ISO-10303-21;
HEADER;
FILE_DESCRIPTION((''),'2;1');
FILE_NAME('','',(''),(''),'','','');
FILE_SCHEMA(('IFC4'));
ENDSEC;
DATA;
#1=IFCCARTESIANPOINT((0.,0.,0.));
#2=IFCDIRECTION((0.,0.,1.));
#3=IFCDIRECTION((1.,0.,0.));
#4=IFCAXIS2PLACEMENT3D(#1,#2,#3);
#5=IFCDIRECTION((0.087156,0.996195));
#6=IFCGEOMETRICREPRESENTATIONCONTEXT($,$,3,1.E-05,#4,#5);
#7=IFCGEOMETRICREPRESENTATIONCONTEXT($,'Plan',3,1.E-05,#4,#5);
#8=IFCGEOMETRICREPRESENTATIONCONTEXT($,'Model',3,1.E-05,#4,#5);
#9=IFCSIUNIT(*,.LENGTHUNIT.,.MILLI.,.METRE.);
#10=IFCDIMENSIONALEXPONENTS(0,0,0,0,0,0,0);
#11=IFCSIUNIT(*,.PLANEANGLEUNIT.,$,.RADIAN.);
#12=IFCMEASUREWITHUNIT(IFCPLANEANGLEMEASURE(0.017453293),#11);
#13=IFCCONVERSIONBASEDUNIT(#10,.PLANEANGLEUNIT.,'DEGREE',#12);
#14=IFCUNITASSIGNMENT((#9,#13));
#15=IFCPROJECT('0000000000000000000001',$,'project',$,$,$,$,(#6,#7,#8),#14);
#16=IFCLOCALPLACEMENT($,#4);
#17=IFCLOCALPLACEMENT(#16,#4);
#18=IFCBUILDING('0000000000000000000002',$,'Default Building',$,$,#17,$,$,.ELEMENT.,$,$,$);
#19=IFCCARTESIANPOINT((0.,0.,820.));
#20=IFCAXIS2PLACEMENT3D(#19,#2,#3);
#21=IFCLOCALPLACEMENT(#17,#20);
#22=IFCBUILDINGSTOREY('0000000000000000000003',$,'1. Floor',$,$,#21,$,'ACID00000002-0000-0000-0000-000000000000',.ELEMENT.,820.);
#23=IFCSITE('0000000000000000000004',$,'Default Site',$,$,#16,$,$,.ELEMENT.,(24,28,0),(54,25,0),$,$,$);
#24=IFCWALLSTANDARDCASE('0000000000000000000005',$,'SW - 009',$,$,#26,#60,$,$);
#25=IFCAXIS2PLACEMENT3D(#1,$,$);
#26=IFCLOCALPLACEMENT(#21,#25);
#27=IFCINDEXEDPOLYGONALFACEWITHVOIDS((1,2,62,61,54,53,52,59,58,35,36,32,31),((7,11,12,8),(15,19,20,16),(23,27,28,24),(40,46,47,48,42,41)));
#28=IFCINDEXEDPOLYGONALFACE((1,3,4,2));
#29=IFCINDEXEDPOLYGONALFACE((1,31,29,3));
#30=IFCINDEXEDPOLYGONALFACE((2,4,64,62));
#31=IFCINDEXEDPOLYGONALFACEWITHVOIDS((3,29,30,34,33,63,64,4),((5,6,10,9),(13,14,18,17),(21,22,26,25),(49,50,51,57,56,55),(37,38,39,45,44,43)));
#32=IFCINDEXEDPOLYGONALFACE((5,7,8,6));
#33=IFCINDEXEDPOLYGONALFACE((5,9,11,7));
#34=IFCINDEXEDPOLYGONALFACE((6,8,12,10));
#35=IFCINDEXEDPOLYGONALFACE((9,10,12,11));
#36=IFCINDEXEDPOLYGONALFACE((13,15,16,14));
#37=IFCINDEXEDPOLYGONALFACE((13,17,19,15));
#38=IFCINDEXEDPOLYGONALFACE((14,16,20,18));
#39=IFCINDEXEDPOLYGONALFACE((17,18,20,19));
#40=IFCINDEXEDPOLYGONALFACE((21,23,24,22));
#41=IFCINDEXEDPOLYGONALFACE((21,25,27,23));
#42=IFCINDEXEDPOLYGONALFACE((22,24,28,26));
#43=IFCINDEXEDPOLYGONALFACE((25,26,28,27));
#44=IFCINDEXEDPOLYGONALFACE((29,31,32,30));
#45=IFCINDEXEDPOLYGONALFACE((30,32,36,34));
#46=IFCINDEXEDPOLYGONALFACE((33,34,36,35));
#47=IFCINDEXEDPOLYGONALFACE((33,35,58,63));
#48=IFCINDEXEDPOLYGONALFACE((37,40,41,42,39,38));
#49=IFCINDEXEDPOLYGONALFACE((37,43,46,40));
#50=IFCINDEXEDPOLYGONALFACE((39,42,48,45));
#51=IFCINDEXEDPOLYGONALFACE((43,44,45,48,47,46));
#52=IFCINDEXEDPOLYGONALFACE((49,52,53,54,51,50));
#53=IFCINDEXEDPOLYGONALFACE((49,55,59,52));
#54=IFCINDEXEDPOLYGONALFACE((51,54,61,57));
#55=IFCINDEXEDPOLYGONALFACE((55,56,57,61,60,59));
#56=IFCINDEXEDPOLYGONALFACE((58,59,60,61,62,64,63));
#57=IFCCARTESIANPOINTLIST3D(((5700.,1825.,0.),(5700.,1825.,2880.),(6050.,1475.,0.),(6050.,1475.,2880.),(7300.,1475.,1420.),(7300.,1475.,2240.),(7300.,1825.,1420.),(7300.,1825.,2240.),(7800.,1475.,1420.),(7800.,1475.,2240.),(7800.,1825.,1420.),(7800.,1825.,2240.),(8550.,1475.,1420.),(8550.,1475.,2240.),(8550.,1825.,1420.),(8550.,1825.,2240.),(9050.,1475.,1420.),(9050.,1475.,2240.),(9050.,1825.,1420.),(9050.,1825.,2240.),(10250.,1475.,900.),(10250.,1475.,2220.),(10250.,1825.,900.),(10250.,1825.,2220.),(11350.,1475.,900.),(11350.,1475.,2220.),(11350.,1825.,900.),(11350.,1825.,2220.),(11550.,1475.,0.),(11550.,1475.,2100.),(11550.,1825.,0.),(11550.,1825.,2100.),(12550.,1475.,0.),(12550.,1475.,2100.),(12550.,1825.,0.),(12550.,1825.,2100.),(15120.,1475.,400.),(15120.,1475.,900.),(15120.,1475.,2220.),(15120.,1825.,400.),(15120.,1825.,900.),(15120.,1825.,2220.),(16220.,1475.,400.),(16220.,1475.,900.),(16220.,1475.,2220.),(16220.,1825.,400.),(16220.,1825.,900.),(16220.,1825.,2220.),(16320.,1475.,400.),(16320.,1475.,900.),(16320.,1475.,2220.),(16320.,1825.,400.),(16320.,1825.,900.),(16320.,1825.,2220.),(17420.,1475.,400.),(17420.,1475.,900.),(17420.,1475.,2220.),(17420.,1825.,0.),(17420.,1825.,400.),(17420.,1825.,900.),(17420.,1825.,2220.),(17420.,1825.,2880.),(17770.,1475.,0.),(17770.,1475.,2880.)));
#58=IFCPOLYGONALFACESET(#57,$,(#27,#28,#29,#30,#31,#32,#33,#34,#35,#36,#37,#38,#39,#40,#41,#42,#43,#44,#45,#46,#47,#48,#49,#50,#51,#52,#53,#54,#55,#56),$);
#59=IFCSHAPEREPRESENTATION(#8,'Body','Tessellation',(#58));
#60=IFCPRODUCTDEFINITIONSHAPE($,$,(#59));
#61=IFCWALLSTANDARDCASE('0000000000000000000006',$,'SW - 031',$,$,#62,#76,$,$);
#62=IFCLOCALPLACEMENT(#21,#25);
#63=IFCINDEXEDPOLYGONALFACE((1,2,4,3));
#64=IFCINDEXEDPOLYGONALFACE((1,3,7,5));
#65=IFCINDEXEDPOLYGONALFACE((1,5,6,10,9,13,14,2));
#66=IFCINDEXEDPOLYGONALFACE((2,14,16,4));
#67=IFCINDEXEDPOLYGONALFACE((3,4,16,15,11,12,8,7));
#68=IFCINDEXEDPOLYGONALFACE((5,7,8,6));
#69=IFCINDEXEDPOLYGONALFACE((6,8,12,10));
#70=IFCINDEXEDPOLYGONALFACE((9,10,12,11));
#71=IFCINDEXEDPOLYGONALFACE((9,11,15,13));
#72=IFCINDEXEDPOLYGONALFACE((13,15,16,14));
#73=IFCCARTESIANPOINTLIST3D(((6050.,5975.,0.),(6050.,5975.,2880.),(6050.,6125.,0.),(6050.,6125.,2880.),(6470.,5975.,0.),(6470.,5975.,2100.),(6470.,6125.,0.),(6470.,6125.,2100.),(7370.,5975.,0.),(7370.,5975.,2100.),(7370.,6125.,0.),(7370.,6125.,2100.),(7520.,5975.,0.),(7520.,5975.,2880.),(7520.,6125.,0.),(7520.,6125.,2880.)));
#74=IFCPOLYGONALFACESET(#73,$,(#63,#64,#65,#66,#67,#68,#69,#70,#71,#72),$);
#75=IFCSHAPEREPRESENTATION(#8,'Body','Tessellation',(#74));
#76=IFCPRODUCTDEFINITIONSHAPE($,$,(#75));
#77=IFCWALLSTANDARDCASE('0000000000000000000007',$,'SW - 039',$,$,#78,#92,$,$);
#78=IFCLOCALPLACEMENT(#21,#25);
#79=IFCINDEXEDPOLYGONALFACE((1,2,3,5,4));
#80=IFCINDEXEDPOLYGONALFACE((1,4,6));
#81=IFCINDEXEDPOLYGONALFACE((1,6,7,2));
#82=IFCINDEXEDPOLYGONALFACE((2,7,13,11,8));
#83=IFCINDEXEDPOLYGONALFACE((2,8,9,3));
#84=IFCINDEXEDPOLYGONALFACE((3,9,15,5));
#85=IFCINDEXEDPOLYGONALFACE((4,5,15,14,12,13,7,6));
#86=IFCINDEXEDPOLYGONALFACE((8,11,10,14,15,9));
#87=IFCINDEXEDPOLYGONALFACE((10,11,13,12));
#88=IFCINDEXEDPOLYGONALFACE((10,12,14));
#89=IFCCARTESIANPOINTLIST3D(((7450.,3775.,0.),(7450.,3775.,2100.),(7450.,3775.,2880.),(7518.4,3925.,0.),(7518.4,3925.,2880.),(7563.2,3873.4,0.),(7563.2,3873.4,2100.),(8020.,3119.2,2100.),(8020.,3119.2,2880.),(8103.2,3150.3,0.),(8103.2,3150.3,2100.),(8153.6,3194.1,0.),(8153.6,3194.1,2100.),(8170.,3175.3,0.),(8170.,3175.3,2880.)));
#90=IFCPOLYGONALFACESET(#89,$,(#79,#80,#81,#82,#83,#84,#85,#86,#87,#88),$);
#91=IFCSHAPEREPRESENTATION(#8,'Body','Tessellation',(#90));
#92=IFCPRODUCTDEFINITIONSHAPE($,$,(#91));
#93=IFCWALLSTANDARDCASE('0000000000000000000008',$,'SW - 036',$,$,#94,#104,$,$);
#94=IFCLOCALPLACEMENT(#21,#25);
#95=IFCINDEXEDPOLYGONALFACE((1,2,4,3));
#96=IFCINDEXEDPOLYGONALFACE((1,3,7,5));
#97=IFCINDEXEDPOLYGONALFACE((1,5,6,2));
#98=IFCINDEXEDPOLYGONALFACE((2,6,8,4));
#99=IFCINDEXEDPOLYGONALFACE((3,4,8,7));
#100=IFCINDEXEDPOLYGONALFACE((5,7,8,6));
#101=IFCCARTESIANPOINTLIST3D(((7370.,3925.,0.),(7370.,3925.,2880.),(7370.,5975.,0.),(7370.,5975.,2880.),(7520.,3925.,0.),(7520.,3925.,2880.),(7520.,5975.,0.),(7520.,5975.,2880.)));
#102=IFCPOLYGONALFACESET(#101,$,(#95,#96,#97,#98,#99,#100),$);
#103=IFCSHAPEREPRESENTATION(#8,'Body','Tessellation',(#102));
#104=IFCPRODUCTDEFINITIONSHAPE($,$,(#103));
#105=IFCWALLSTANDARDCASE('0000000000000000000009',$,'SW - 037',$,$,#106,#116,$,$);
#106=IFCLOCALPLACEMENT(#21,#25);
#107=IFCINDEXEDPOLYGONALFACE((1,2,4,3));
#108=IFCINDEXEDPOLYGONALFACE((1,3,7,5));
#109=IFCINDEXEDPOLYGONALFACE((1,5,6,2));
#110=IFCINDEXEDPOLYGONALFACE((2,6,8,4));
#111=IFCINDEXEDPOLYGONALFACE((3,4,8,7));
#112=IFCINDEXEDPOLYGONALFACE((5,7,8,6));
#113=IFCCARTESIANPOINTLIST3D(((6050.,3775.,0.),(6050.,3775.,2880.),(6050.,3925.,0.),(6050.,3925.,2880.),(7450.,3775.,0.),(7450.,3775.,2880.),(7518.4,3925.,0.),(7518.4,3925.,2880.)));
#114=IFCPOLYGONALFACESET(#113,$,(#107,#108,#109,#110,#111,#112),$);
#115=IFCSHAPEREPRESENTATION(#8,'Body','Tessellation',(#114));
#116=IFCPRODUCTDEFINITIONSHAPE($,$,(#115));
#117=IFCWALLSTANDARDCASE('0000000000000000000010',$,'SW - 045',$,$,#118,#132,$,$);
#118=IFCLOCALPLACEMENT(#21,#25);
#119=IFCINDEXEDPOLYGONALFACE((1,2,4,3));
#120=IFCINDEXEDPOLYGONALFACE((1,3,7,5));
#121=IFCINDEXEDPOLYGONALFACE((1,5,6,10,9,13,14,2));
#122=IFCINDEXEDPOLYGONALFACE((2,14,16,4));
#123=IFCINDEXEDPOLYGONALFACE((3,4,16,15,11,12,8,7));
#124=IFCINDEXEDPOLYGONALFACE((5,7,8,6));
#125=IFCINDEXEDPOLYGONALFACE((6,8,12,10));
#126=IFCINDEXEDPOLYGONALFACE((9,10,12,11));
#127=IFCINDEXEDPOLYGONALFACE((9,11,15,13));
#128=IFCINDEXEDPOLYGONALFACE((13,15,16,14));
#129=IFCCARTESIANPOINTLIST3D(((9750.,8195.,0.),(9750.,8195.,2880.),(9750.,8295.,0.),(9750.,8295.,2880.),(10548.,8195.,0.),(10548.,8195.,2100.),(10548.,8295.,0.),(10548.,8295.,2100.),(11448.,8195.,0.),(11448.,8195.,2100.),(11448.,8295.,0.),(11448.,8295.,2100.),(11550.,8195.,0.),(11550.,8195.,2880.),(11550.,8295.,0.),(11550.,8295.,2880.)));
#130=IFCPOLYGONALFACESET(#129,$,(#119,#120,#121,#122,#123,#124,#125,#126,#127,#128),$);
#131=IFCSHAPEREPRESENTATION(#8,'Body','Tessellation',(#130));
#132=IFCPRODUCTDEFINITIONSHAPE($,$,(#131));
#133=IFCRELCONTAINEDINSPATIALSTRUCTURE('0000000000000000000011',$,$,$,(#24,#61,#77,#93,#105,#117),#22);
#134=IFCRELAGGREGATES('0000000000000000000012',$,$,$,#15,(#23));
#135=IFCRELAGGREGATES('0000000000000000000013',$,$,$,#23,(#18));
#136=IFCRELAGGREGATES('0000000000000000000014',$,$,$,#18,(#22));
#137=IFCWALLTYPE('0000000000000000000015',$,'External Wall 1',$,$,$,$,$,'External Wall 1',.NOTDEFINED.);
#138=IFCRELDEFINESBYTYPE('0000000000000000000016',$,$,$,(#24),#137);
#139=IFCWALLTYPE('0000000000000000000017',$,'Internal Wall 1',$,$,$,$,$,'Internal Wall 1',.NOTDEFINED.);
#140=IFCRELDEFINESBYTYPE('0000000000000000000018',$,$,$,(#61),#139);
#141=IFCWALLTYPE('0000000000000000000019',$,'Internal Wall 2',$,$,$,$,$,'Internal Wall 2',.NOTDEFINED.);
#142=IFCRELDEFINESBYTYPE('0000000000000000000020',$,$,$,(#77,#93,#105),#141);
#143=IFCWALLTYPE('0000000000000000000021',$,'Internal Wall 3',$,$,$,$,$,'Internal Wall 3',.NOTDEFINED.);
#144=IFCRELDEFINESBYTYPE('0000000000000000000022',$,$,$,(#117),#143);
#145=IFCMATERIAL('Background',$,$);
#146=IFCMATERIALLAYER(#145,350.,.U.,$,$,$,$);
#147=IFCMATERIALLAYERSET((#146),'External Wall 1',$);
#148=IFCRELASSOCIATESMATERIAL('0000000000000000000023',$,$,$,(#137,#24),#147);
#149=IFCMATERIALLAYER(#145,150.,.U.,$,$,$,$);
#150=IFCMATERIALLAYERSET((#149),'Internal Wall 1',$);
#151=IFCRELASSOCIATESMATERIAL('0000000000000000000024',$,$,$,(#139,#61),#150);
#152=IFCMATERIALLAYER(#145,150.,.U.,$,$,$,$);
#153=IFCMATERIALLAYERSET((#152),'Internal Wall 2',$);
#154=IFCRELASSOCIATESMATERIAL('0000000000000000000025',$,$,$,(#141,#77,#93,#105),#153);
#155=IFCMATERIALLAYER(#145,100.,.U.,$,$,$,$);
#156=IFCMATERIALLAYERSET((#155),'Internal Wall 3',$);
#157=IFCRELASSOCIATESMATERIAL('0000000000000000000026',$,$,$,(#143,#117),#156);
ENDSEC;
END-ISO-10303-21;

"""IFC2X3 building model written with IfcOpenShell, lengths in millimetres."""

from ifc_helpers import new_model, entity, si_unit, converted_unit, direction, frame, frame_2d, origin_with_axes, place, context, project, spatial, polyline, rectangle, outline, extrude, material, layer, layer_set, layer_usage, type_object, element, save


model = new_model("IFC2X3")

# Units and contexts
context_of_model = context(None, 3, precision=1e-05, world=origin_with_axes(), true_north=direction((0.087156, 0.996195)))
plan_context = context("Plan", 3, precision=1e-05, world=origin_with_axes(), true_north=direction((0.087156, 0.996195)))
model_context = context("Model", 3, precision=1e-05, world=origin_with_axes(), true_north=direction((0.087156, 0.996195)))
ifc_project = project(units=[si_unit("LENGTHUNIT", "METRE", prefix="MILLI"), converted_unit("PLANEANGLEUNIT", "DEGREE", entity("IfcPlaneAngleMeasure", 0.017453293), si_unit("PLANEANGLEUNIT", "RADIAN"), dimensions=[0, 0, 0, 0, 0, 0, 0])], contexts=[context_of_model, plan_context, model_context])

# Site, building, storey
site_placement = place(None, origin_with_axes())
site = spatial("IfcSite", under=ifc_project, at=site_placement, Name="Default Site", CompositionType="ELEMENT", RefLatitude=(24, 28, 0), RefLongitude=(54, 25, 0))
building_placement = place(site_placement, origin_with_axes())
building = spatial("IfcBuilding", under=site, at=building_placement, Name="Default Building", CompositionType="ELEMENT")
storey_placement = place(building_placement, frame((0.0, 0.0, 820.0), z_axis=(0.0, 0.0, 1.0), x_axis=(1.0, 0.0, 0.0)))
storey = spatial("IfcBuildingStorey", under=building, at=storey_placement, Name="1. Floor", LongName="ACID00000002-0000-0000-0000-000000000000", CompositionType="ELEMENT", Elevation=820.0)

# Shared definitions
ifc_material_1 = material(Name="Background")

# Shared definitions
ifc_layer_1 = layer(ifc_material_1, 350.0, ventilated="UNKNOWN")
ifc_layer_set_1 = layer_set([ifc_layer_1], Name="External Wall 1")
wall_type_1 = type_object("IfcWallType", Name="External Wall 1", ElementType="External Wall 1", PredefinedType="NOTDEFINED", material=ifc_layer_set_1)

# Wall, openings
ifc_layer_usage_1 = layer_usage(ifc_layer_set_1, "AXIS2", "POSITIVE", 0.0)
wall_1_placement = place(storey_placement, frame((6050.0, 1475.0, 0.0), z_axis=(0.0, 0.0, 1.0), x_axis=(1.0, 0.0, 0.0)))
wall_1 = element("IfcWallStandardCase", 1, at=wall_1_placement, inside=storey, type_object=wall_type_1, material=ifc_layer_usage_1, Name="SW - 009", context=model_context, shape_type="SweptSolid", body=[
    extrude(outline(polyline([(0.0, 0.0), (11720.0, 0.0), (11370.0, 350.0), (-350.0, 350.0), (0.0, 0.0)])), origin_with_axes(), (0.0, 0.0, 1.0), 2880.0),
])
opening_1_placement = place(wall_1_placement, frame((6000.0, 0.0, 0.0), z_axis=(0.0, 0.0, 1.0), x_axis=(1.0, 0.0, 0.0)))
element("IfcOpeningElement", 2, at=opening_1_placement, cuts=wall_1, ObjectType="Opening", context=model_context, shape_type="SweptSolid", body=[
    extrude(rectangle(XDim=1000.0, YDim=2100.0, at=frame_2d((0.0, 1050.0), x_axis=(-1.0, 0.0))), frame((0.0, 0.0, 0.0), z_axis=(0.0, 1.0, 0.0), x_axis=(-1.0, 0.0, 0.0)), (0.0, 0.0, 1.0), 350.0),
])
opening_2_placement = place(wall_1_placement, frame((10820.0, 0.0, 900.0), z_axis=(0.0, 0.0, 1.0), x_axis=(1.0, 0.0, 0.0)))
element("IfcOpeningElement", 3, at=opening_2_placement, cuts=wall_1, ObjectType="Opening", context=model_context, shape_type="SweptSolid", body=[
    extrude(outline(polyline([(-550.0, 0.0), (550.0, 0.0), (550.0, 1320.0), (-550.0, 1320.0), (-550.0, 0.0)])), frame((0.0, 0.0, 0.0), z_axis=(0.0, 1.0, 0.0), x_axis=(-1.0, 0.0, 0.0)), (0.0, 0.0, 1.0), 350.0),
])
opening_3_placement = place(wall_1_placement, frame((9620.0, 0.0, 900.0), z_axis=(0.0, 0.0, 1.0), x_axis=(1.0, 0.0, 0.0)))
element("IfcOpeningElement", 4, at=opening_3_placement, cuts=wall_1, ObjectType="Opening", context=model_context, shape_type="SweptSolid", body=[
    extrude(outline(polyline([(-550.0, 0.0), (550.0, 0.0), (550.0, 1320.0), (-550.0, 1320.0), (-550.0, 0.0)])), frame((0.0, 0.0, 0.0), z_axis=(0.0, 1.0, 0.0), x_axis=(-1.0, 0.0, 0.0)), (0.0, 0.0, 1.0), 350.0),
])
opening_4_placement = place(wall_1_placement, frame((10820.0, 0.0, 400.0), z_axis=(0.0, 0.0, 1.0), x_axis=(1.0, 0.0, 0.0)))
element("IfcOpeningElement", 5, at=opening_4_placement, cuts=wall_1, ObjectType="Opening", context=model_context, shape_type="SweptSolid", body=[
    extrude(outline(polyline([(-550.0, 0.0), (550.0, 0.0), (550.0, 500.0), (-550.0, 500.0), (-550.0, 0.0)])), frame((0.0, 0.0, 0.0), z_axis=(0.0, 1.0, 0.0), x_axis=(-1.0, 0.0, 0.0)), (0.0, 0.0, 1.0), 350.0),
])
opening_5_placement = place(wall_1_placement, frame((9620.0, 0.0, 400.0), z_axis=(0.0, 0.0, 1.0), x_axis=(1.0, 0.0, 0.0)))
element("IfcOpeningElement", 6, at=opening_5_placement, cuts=wall_1, ObjectType="Opening", context=model_context, shape_type="SweptSolid", body=[
    extrude(outline(polyline([(-550.0, 0.0), (550.0, 0.0), (550.0, 500.0), (-550.0, 500.0), (-550.0, 0.0)])), frame((0.0, 0.0, 0.0), z_axis=(0.0, 1.0, 0.0), x_axis=(-1.0, 0.0, 0.0)), (0.0, 0.0, 1.0), 350.0),
])
opening_6_placement = place(wall_1_placement, frame((4750.0, 0.0, 900.0), z_axis=(0.0, 0.0, 1.0), x_axis=(1.0, 0.0, 0.0)))
element("IfcOpeningElement", 7, at=opening_6_placement, cuts=wall_1, ObjectType="Opening", context=model_context, shape_type="SweptSolid", body=[
    extrude(rectangle(XDim=1100.0, YDim=1320.0, at=frame_2d((0.0, 660.0), x_axis=(1.0, 0.0))), frame((0.0, 0.0, 0.0), z_axis=(0.0, 1.0, 0.0), x_axis=(-1.0, 0.0, 0.0)), (0.0, 0.0, 1.0), 350.0),
])
opening_7_placement = place(wall_1_placement, frame((1500.0, 0.0, 1420.0), z_axis=(0.0, 0.0, 1.0), x_axis=(1.0, 0.0, 0.0)))
element("IfcOpeningElement", 8, at=opening_7_placement, cuts=wall_1, ObjectType="Opening", context=model_context, shape_type="SweptSolid", body=[
    extrude(rectangle(XDim=500.0, YDim=820.0, at=frame_2d((0.0, 410.0), x_axis=(1.0, 0.0))), frame((0.0, 0.0, 0.0), z_axis=(0.0, 1.0, 0.0), x_axis=(-1.0, 0.0, 0.0)), (0.0, 0.0, 1.0), 350.0),
])
opening_8_placement = place(wall_1_placement, frame((2750.0, 0.0, 1420.0), z_axis=(0.0, 0.0, 1.0), x_axis=(1.0, 0.0, 0.0)))
element("IfcOpeningElement", 9, at=opening_8_placement, cuts=wall_1, ObjectType="Opening", context=model_context, shape_type="SweptSolid", body=[
    extrude(rectangle(XDim=500.0, YDim=820.0, at=frame_2d((0.0, 410.0), x_axis=(1.0, 0.0))), frame((0.0, 0.0, 0.0), z_axis=(0.0, 1.0, 0.0), x_axis=(-1.0, 0.0, 0.0)), (0.0, 0.0, 1.0), 350.0),
])

# Walls, openings
ifc_layer_2 = layer(ifc_material_1, 150.0, ventilated="UNKNOWN")
ifc_layer_set_2 = layer_set([ifc_layer_2], Name="Internal Wall 1")
ifc_layer_usage_2 = layer_usage(ifc_layer_set_2, "AXIS2", "NEGATIVE", 0.0)
wall_type_2 = type_object("IfcWallType", Name="Internal Wall 1", ElementType="Internal Wall 1", PredefinedType="NOTDEFINED", material=ifc_layer_set_2)
wall_2_placement = place(storey_placement, frame((7520.0, 5975.0, 0.0), z_axis=(0.0, 0.0, 1.0), x_axis=(-1.0, 0.0, 0.0)))
wall_2 = element("IfcWallStandardCase", 10, at=wall_2_placement, inside=storey, type_object=wall_type_2, material=ifc_layer_usage_2, Name="SW - 031", context=model_context, shape_type="SweptSolid", body=[
    extrude(outline(polyline([(0.0, -150.0), (1470.0, -150.0), (1470.0, 0.0), (0.0, 0.0), (0.0, -150.0)])), origin_with_axes(), (0.0, 0.0, 1.0), 2880.0),
])
opening_9_placement = place(wall_2_placement, frame((600.0, -150.0, 0.0), z_axis=(0.0, 0.0, 1.0), x_axis=(1.0, 0.0, 0.0)))
element("IfcOpeningElement", 11, at=opening_9_placement, cuts=wall_2, ObjectType="Opening", context=model_context, shape_type="SweptSolid", body=[
    extrude(rectangle(XDim=900.0, YDim=2100.0, at=frame_2d((0.0, 1050.0), x_axis=(-1.0, 0.0))), frame((0.0, 0.0, 0.0), z_axis=(0.0, 1.0, 0.0), x_axis=(-1.0, 0.0, 0.0)), (0.0, 0.0, 1.0), 150.0),
])
ifc_layer_3 = layer(ifc_material_1, 150.0, ventilated="UNKNOWN")
ifc_layer_set_3 = layer_set([ifc_layer_3], Name="Internal Wall 2")
ifc_layer_usage_3 = layer_usage(ifc_layer_set_3, "AXIS2", "NEGATIVE", 0.0)
wall_type_3 = type_object("IfcWallType", Name="Internal Wall 2", ElementType="Internal Wall 2", PredefinedType="NOTDEFINED", material=ifc_layer_set_3)
wall_3_placement = place(storey_placement, frame((8020.0, 3119.2, 0.0), z_axis=(0.0, 0.0, 1.0), x_axis=(-0.656, 0.754761, 0.0)))
wall_3 = element("IfcWallStandardCase", 12, at=wall_3_placement, inside=storey, type_object=wall_type_3, material=ifc_layer_usage_3, Name="SW - 039", context=model_context, shape_type="SweptSolid", body=[
    extrude(outline(polyline([(-56.1, -150.0), (937.3, -150.0), (868.9, 0.0), (0.0, 0.0), (-56.1, -150.0)])), origin_with_axes(), (0.0, 0.0, 1.0), 2880.0),
])
opening_10_placement = place(wall_3_placement, frame((418.9, -150.0, 0.0), z_axis=(0.0, 0.0, 1.0), x_axis=(1.0, 0.0, 0.0)))
element("IfcOpeningElement", 13, at=opening_10_placement, cuts=wall_3, ObjectType="Opening", context=model_context, shape_type="SweptSolid", body=[
    extrude(outline(polyline([(-450.0, 0.0), (450.0, 0.0), (450.0, 2100.0), (-450.0, 2100.0), (-450.0, 0.0)])), frame((0.0, 0.0, 0.0), z_axis=(0.0, 1.0, 0.0), x_axis=(-1.0, 0.0, 0.0)), (0.0, 0.0, 1.0), 150.0),
])

# Walls
ifc_layer_usage_4 = layer_usage(ifc_layer_set_3, "AXIS2", "POSITIVE", 0.0)
wall_4_placement = place(storey_placement, frame((7370.0, 5975.0, 0.0), z_axis=(0.0, 0.0, 1.0), x_axis=(0.0, -1.0, 0.0)))
element("IfcWallStandardCase", 14, at=wall_4_placement, inside=storey, type_object=wall_type_3, material=ifc_layer_usage_4, Name="SW - 036", context=model_context, shape_type="SweptSolid", body=[
    extrude(outline(polyline([(0.0, 0.0), (2050.0, 0.0), (2050.0, 150.0), (0.0, 150.0), (0.0, 0.0)])), origin_with_axes(), (0.0, 0.0, 1.0), 2880.0),
])
ifc_layer_usage_5 = layer_usage(ifc_layer_set_3, "AXIS2", "NEGATIVE", 0.0)
wall_5_placement = place(storey_placement, frame((7450.0, 3775.0, 0.0), z_axis=(0.0, 0.0, 1.0), x_axis=(-1.0, 0.0, 0.0)))
element("IfcWallStandardCase", 15, at=wall_5_placement, inside=storey, type_object=wall_type_3, material=ifc_layer_usage_5, Name="SW - 037", context=model_context, shape_type="SweptSolid", body=[
    extrude(outline(polyline([(-68.4, -150.0), (1400.0, -150.0), (1400.0, 0.0), (0.0, 0.0), (-68.4, -150.0)])), origin_with_axes(), (0.0, 0.0, 1.0), 2880.0),
])
ifc_layer_4 = layer(ifc_material_1, 100.0, ventilated="UNKNOWN")
ifc_layer_set_4 = layer_set([ifc_layer_4], Name="Internal Wall 3")
wall_type_4 = type_object("IfcWallType", Name="Internal Wall 3", ElementType="Internal Wall 3", PredefinedType="NOTDEFINED", material=ifc_layer_set_4)

# Wall, opening
ifc_layer_usage_6 = layer_usage(ifc_layer_set_4, "AXIS2", "POSITIVE", 0.0)
wall_6_placement = place(storey_placement, frame((9750.0, 8195.0, 0.0), z_axis=(0.0, 0.0, 1.0), x_axis=(1.0, 0.0, 0.0)))
wall_6 = element("IfcWallStandardCase", 16, at=wall_6_placement, inside=storey, type_object=wall_type_4, material=ifc_layer_usage_6, Name="SW - 045", context=model_context, shape_type="SweptSolid", body=[
    extrude(outline(polyline([(0.0, 0.0), (1800.0, 0.0), (1800.0, 100.0), (0.0, 100.0), (0.0, 0.0)])), origin_with_axes(), (0.0, 0.0, 1.0), 2880.0),
])
opening_11_placement = place(wall_6_placement, frame((1248.0, 0.0, 0.0), z_axis=(0.0, 0.0, 1.0), x_axis=(1.0, 0.0, 0.0)))
element("IfcOpeningElement", 17, at=opening_11_placement, cuts=wall_6, ObjectType="Opening", context=model_context, shape_type="SweptSolid", body=[
    extrude(rectangle(XDim=900.0, YDim=2100.0, at=frame_2d((0.0, 1050.0), x_axis=(-1.0, 0.0))), frame((0.0, 0.0, 0.0), z_axis=(0.0, 1.0, 0.0), x_axis=(-1.0, 0.0, 0.0)), (0.0, 0.0, 1.0), 100.0),
])

save(model, "model.ifc")
